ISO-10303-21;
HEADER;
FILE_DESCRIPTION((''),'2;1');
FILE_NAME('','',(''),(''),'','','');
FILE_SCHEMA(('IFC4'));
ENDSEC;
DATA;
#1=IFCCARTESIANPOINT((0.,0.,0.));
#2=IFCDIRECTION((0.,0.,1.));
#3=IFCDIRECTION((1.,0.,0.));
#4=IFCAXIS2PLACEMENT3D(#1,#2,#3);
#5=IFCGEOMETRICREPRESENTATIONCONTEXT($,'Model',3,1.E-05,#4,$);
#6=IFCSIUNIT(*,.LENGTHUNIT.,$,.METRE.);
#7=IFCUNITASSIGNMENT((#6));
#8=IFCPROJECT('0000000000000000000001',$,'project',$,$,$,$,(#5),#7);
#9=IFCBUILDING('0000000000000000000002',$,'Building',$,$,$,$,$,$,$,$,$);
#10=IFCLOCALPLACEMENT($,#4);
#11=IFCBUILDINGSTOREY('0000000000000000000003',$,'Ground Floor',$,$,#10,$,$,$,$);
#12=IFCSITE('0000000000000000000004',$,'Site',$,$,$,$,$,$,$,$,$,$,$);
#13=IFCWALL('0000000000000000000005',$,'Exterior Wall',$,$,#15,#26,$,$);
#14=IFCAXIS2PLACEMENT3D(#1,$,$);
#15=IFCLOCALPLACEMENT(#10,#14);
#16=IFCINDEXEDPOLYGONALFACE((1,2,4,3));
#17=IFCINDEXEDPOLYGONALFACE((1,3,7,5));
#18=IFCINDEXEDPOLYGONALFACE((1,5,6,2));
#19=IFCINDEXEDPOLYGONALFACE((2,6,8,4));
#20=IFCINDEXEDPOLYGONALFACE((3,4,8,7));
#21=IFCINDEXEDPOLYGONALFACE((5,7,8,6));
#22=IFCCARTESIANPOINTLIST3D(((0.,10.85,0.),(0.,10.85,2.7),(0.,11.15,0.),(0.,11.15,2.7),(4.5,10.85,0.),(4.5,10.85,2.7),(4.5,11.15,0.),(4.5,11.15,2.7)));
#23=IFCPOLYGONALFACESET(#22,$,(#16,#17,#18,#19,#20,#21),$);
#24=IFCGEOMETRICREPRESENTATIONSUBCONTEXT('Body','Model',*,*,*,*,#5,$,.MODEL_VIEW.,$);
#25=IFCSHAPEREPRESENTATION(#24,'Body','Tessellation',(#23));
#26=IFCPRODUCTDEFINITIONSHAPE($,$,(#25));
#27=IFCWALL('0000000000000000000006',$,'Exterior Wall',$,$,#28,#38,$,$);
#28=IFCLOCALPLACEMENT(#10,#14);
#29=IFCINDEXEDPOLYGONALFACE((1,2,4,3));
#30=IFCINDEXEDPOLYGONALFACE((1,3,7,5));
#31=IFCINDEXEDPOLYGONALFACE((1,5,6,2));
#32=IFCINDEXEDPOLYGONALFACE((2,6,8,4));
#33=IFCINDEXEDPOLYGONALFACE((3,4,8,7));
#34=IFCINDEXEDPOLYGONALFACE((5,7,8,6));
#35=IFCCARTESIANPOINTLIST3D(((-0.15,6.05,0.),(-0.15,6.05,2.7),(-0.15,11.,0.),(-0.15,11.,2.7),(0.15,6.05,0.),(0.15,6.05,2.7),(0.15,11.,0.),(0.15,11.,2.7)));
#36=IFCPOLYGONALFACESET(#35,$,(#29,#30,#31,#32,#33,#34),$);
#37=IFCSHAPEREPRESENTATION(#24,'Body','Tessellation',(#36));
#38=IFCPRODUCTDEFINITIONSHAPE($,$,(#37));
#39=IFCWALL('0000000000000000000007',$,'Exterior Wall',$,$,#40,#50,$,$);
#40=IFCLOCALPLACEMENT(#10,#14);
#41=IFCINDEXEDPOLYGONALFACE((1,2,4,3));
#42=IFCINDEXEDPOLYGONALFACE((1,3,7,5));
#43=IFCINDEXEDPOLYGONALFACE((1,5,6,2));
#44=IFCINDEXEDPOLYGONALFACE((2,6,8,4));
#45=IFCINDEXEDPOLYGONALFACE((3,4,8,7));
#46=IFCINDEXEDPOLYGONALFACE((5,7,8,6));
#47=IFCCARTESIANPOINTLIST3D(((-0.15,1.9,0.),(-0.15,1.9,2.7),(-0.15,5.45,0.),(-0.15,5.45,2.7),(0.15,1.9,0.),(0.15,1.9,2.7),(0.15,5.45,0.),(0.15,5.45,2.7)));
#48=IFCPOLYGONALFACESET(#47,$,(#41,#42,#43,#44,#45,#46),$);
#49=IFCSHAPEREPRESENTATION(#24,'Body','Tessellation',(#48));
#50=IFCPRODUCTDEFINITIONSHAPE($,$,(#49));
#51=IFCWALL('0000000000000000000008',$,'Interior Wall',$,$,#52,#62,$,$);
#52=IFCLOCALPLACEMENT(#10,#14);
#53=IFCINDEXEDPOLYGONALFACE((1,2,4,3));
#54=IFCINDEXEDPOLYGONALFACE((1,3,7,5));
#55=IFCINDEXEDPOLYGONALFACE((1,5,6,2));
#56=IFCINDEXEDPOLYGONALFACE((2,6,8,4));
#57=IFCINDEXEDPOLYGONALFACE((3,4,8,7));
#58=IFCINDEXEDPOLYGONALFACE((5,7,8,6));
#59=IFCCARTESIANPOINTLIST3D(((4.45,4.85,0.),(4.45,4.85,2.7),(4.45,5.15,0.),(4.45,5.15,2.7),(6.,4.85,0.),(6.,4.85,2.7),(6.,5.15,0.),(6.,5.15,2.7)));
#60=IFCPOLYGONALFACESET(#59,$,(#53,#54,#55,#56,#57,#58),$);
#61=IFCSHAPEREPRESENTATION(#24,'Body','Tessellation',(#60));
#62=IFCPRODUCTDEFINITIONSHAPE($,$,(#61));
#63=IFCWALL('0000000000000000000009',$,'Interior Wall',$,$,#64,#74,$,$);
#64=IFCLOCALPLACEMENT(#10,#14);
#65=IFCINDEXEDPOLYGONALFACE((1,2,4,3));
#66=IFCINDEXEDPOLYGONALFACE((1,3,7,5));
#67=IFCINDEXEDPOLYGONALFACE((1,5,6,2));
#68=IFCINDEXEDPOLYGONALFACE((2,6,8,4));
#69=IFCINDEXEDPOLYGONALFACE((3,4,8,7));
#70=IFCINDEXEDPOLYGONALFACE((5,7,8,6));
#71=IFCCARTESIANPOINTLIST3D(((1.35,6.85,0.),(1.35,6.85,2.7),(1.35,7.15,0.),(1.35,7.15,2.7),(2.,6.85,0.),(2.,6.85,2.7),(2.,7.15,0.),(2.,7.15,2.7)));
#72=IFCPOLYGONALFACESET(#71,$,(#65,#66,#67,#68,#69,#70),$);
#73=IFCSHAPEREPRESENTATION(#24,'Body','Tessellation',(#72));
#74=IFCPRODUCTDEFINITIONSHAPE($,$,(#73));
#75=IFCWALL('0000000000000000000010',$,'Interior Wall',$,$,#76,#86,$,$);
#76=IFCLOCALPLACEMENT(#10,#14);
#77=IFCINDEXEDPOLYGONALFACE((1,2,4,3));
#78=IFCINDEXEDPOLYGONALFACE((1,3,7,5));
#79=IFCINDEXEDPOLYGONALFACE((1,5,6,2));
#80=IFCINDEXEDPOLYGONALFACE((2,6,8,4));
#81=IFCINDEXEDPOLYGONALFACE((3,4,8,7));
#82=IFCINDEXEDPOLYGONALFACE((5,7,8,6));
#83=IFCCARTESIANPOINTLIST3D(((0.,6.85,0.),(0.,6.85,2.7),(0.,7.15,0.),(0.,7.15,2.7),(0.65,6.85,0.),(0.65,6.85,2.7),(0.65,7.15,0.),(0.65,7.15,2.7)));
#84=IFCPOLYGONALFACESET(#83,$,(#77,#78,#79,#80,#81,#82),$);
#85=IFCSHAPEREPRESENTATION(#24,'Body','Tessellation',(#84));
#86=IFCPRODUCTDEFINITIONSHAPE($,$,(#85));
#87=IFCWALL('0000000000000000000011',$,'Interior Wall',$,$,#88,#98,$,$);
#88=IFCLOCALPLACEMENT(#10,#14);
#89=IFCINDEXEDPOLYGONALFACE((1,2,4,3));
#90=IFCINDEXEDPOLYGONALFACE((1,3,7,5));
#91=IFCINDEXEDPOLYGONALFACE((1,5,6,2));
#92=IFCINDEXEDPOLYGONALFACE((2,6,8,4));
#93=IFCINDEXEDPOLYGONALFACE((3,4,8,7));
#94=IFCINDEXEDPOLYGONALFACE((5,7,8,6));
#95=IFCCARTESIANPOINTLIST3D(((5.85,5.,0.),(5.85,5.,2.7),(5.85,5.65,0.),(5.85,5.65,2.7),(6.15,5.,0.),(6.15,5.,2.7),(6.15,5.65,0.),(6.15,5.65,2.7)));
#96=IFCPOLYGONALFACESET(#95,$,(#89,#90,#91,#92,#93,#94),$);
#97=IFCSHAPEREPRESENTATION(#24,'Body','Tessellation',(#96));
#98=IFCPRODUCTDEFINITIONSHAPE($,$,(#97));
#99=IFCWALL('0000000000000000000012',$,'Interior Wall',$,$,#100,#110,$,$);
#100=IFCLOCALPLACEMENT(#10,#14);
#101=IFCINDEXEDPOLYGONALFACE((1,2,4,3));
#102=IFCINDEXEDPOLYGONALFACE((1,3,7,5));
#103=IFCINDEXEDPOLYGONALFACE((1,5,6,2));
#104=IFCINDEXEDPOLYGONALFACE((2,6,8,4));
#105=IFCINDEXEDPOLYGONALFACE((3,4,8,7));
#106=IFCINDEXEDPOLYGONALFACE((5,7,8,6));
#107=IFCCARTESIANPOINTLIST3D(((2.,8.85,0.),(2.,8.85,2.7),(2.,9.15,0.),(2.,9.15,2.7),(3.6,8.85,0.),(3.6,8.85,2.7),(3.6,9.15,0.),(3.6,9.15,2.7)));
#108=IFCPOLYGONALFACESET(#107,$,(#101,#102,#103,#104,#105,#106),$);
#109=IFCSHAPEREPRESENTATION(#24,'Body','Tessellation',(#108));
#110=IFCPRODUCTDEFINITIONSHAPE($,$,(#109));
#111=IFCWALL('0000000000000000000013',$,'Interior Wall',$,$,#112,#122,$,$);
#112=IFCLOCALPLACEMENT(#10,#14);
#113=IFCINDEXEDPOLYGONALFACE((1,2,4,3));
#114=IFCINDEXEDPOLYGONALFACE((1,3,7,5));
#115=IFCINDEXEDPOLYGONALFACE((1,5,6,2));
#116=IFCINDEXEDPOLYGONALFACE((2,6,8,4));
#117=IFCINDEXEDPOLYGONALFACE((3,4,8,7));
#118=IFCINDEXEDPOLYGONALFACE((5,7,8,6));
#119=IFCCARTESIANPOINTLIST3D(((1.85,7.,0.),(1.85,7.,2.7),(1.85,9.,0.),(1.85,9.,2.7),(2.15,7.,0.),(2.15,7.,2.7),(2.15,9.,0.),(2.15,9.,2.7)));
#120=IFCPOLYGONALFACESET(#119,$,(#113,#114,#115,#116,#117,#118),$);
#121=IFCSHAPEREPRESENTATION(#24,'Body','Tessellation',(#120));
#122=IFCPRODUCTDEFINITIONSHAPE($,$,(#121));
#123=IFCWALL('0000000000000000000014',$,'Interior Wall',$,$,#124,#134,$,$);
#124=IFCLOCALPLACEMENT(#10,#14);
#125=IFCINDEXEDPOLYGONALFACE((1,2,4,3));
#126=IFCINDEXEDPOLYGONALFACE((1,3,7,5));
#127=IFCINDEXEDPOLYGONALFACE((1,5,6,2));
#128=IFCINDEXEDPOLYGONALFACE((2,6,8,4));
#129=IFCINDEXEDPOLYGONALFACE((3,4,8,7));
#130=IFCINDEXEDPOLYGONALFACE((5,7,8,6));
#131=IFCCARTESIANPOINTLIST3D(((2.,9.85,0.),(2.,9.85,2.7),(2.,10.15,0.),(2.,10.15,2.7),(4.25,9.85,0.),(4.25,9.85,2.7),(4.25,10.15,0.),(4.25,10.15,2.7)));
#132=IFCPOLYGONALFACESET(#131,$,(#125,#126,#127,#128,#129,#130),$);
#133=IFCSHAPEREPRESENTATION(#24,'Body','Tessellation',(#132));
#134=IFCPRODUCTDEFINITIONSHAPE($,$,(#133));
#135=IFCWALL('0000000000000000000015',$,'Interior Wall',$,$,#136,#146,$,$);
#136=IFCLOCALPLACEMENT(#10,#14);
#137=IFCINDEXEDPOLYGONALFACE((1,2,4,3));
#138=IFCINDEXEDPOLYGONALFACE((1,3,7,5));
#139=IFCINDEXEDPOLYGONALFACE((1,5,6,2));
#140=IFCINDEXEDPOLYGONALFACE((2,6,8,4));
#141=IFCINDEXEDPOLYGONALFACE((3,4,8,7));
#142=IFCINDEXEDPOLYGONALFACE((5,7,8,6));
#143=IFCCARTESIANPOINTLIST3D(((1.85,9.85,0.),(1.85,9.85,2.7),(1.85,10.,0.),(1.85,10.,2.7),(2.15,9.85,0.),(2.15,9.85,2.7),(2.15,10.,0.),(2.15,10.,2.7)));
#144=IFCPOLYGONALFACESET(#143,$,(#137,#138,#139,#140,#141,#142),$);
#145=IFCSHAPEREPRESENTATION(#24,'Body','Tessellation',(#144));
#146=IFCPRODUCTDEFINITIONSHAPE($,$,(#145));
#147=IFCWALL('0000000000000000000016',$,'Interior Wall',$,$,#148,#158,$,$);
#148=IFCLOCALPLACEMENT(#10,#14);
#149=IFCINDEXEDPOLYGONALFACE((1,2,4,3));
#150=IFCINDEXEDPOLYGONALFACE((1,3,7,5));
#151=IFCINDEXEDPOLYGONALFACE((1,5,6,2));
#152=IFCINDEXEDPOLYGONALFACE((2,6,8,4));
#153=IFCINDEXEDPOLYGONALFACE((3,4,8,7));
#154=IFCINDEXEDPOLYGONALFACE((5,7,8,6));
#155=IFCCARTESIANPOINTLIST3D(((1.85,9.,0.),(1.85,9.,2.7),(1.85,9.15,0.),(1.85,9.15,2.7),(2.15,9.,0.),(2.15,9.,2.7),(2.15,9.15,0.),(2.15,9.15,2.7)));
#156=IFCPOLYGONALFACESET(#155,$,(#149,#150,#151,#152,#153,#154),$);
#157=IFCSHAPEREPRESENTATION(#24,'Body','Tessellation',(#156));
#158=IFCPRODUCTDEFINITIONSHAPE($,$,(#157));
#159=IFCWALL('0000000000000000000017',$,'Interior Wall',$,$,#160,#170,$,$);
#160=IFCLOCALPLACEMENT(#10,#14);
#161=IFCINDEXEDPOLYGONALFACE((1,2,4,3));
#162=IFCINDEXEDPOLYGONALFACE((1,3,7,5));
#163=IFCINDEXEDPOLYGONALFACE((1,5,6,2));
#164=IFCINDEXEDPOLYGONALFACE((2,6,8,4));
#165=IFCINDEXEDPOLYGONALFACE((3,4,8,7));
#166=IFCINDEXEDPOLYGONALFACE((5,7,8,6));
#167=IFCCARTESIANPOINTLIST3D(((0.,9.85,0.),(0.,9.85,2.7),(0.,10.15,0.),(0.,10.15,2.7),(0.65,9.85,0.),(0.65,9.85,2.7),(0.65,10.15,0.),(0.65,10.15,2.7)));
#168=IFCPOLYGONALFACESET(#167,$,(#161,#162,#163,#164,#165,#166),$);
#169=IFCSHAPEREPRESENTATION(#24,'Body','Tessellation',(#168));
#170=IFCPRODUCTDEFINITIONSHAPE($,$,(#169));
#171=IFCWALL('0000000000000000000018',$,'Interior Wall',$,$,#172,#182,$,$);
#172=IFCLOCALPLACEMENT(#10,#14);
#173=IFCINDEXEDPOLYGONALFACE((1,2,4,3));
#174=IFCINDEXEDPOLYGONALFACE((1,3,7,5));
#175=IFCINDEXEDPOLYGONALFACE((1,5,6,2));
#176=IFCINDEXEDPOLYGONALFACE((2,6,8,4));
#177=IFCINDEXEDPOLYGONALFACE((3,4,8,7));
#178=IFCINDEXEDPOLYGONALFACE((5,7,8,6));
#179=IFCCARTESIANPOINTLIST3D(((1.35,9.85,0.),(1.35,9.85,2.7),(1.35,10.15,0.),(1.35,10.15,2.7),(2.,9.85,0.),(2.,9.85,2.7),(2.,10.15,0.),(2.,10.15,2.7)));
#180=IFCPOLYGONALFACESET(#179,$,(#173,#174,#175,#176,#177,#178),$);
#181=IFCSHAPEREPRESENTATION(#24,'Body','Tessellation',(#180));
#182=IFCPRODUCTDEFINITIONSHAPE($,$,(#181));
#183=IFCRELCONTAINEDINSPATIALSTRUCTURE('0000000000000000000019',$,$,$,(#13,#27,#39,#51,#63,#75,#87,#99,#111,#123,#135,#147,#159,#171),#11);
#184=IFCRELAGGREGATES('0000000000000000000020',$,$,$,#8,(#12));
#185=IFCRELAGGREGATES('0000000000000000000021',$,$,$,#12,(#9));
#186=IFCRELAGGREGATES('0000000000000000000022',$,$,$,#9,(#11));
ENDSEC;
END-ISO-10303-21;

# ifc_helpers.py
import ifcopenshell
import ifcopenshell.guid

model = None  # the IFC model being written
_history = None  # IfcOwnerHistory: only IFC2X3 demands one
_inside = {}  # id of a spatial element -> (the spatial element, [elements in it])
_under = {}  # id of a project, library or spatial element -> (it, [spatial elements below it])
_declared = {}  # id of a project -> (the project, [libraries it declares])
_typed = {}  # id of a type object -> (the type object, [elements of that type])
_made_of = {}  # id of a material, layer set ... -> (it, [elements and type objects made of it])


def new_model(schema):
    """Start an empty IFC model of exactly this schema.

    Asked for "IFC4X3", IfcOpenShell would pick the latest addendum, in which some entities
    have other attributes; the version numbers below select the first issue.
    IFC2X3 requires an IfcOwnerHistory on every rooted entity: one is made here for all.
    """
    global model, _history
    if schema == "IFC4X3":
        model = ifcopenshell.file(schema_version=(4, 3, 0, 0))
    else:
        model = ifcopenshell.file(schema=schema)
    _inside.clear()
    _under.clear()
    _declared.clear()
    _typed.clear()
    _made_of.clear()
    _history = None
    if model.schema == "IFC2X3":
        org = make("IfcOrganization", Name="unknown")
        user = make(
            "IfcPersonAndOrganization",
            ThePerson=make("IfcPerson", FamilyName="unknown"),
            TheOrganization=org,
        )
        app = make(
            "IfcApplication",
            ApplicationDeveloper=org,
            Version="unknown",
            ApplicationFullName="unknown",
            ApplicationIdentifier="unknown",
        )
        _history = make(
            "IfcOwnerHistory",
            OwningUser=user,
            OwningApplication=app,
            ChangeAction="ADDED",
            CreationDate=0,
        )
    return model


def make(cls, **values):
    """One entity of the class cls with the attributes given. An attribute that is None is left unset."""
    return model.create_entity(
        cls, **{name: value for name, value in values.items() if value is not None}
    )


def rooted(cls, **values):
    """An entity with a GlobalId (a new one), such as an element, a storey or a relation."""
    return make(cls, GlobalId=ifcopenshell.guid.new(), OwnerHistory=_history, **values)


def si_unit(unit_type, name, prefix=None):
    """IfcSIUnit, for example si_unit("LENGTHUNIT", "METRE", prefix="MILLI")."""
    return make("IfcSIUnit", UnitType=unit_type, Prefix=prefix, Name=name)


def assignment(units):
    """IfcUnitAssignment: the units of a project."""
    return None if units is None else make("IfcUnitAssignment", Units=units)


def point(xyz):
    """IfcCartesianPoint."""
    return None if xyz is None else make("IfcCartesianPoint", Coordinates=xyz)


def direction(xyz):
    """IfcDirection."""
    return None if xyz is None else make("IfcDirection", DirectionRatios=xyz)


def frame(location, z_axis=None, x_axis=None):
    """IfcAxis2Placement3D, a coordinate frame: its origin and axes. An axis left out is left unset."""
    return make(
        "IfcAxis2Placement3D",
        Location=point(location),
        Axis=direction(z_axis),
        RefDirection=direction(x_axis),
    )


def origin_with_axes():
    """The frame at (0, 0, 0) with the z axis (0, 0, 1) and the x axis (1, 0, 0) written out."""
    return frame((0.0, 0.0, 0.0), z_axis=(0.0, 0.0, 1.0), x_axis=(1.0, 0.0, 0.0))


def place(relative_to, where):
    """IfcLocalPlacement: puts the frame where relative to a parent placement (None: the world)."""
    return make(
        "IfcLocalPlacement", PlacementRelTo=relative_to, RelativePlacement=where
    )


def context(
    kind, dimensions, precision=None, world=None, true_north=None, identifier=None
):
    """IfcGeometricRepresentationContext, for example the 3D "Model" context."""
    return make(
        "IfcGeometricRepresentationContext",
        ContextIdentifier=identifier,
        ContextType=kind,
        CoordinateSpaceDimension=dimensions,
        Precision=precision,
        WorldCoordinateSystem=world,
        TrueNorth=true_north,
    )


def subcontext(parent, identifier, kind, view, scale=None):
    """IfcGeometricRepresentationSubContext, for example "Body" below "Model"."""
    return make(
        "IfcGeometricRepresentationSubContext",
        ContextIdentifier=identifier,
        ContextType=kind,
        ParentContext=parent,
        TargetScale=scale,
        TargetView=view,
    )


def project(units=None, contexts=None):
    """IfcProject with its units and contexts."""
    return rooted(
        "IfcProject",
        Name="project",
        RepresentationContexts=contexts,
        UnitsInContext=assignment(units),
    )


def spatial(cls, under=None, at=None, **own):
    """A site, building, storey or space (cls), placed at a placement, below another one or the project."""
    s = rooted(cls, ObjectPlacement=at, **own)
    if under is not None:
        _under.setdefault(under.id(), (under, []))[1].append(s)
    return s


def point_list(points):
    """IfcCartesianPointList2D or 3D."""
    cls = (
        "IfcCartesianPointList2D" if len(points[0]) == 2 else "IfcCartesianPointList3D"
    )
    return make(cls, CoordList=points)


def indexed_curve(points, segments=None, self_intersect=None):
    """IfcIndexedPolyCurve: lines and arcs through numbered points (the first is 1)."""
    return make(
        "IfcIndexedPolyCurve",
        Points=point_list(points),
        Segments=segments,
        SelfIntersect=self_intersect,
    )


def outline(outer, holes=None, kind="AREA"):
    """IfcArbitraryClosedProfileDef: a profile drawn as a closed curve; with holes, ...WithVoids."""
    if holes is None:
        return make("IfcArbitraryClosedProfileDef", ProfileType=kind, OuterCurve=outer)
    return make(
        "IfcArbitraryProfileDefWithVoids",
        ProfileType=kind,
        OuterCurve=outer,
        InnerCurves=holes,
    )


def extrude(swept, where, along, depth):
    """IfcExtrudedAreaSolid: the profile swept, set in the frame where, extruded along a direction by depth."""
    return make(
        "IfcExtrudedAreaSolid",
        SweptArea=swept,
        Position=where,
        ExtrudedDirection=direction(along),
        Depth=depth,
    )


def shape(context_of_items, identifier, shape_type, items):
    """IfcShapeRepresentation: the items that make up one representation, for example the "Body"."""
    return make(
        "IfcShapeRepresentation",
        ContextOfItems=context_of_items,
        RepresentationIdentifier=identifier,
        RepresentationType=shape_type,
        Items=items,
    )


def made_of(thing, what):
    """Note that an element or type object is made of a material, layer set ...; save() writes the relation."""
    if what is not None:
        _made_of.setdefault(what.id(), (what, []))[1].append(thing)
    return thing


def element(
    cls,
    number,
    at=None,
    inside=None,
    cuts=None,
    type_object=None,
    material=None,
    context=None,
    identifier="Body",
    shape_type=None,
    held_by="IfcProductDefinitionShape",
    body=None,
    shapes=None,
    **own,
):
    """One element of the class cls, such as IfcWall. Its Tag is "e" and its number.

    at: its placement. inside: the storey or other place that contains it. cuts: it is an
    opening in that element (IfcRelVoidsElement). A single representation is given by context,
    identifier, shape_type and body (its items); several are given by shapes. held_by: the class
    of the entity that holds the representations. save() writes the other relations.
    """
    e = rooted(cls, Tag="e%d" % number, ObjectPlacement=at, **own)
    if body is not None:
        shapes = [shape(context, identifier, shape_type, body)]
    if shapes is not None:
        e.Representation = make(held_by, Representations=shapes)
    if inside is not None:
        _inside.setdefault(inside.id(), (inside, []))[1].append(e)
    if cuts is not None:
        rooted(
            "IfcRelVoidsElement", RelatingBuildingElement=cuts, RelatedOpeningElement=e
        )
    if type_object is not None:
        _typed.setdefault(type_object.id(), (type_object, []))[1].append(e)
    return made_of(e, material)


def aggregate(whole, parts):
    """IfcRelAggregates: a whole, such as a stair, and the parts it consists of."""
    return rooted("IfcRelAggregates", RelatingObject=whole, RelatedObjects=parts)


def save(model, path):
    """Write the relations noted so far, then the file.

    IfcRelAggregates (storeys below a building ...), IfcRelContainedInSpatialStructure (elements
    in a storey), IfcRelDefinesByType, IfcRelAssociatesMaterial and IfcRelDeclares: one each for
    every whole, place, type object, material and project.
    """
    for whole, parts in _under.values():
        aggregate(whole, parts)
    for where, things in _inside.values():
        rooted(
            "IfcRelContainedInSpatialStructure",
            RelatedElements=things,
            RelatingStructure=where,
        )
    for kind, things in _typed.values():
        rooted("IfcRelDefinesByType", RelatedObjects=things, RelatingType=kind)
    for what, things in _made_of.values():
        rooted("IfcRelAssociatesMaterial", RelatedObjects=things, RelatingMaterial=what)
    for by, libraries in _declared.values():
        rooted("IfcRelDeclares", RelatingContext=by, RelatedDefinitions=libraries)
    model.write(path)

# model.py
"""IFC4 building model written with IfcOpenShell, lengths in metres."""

from ifc_helpers import new_model, si_unit, frame, origin_with_axes, place, context, subcontext, project, spatial, indexed_curve, outline, extrude, element, save


model = new_model("IFC4")

# Units and contexts
model_context = context("Model", 3, precision=1e-05, world=origin_with_axes())
body_context = subcontext(model_context, "Body", "Model", "MODEL_VIEW")
ifc_project = project(units=[si_unit("LENGTHUNIT", "METRE")], contexts=[model_context])

# Site, building, storey
site = spatial("IfcSite", under=ifc_project, Name="Site")
building = spatial("IfcBuilding", under=site, Name="Building")
storey_placement = place(None, origin_with_axes())
storey = spatial("IfcBuildingStorey", under=building, at=storey_placement, Name="Ground Floor")

# Walls
wall_1_placement = place(storey_placement, frame((4.5, 11.0, 0.0), z_axis=(0.0, 0.0, 1.0), x_axis=(-1.0, 0.0, 0.0)))
element("IfcWall", 1, at=wall_1_placement, inside=storey, Name="Exterior Wall", context=body_context, shape_type="SweptSolid", body=[
    extrude(outline(indexed_curve([(0.0, 0.0), (0.0, 0.3), (4.5, 0.3), (4.5, 0.0), (0.0, 0.0)], self_intersect=False)), frame((0.0, -0.15, 0.0), z_axis=(0.0, 0.0, 1.0), x_axis=(1.0, 0.0, 0.0)), (0.0, 0.0, 1.0), 2.7),
])
wall_2_placement = place(storey_placement, frame((0.0, 11.0, 0.0), z_axis=(0.0, 0.0, 1.0), x_axis=(0.0, -1.0, 0.0)))
element("IfcWall", 2, at=wall_2_placement, inside=storey, Name="Exterior Wall", context=body_context, shape_type="SweptSolid", body=[
    extrude(outline(indexed_curve([(0.0, 0.0), (0.0, 0.3), (4.95, 0.3), (4.95, 0.0), (0.0, 0.0)], self_intersect=False)), frame((0.0, -0.15, 0.0), z_axis=(0.0, 0.0, 1.0), x_axis=(1.0, 0.0, 0.0)), (0.0, 0.0, 1.0), 2.7),
])
wall_3_placement = place(storey_placement, frame((0.0, 5.45, 0.0), z_axis=(0.0, 0.0, 1.0), x_axis=(0.0, -1.0, 0.0)))
element("IfcWall", 3, at=wall_3_placement, inside=storey, Name="Exterior Wall", context=body_context, shape_type="SweptSolid", body=[
    extrude(outline(indexed_curve([(0.0, 0.0), (0.0, 0.3), (3.55, 0.3), (3.55, 0.0), (0.0, 0.0)], self_intersect=False)), frame((0.0, -0.15, 0.0), z_axis=(0.0, 0.0, 1.0), x_axis=(1.0, 0.0, 0.0)), (0.0, 0.0, 1.0), 2.7),
])
wall_4_placement = place(storey_placement, frame((6.0, 5.0, 0.0), z_axis=(0.0, 0.0, 1.0), x_axis=(-1.0, 0.0, 0.0)))
element("IfcWall", 4, at=wall_4_placement, inside=storey, Name="Interior Wall", context=body_context, shape_type="SweptSolid", body=[
    extrude(outline(indexed_curve([(0.0, 0.0), (0.0, 0.3), (1.55, 0.3), (1.55, 0.0), (0.0, 0.0)], self_intersect=False)), frame((0.0, -0.15, 0.0), z_axis=(0.0, 0.0, 1.0), x_axis=(1.0, 0.0, 0.0)), (0.0, 0.0, 1.0), 2.7),
])
for number, where, z_axis, x_axis, name in (
    (5, (2.0, 7.0, 0.0), (0.0, 0.0, 1.0), (-1.0, 0.0, 0.0), "Interior Wall"),
    (6, (0.65, 7.0, 0.0), (0.0, 0.0, 1.0), (-1.0, 0.0, 0.0), "Interior Wall"),
):
    element("IfcWall", number, at=place(storey_placement, frame(where, z_axis=z_axis, x_axis=x_axis)), inside=storey, Name=name, context=body_context, shape_type="SweptSolid", body=[
        extrude(outline(indexed_curve([(0.0, 0.0), (0.0, 0.3), (0.65, 0.3), (0.65, 0.0), (0.0, 0.0)], self_intersect=False)), frame((0.0, -0.15, 0.0), z_axis=(0.0, 0.0, 1.0), x_axis=(1.0, 0.0, 0.0)), (0.0, 0.0, 1.0), 2.7),
    ])
wall_5_placement = place(storey_placement, frame((6.0, 5.0, 0.0), z_axis=(0.0, 0.0, 1.0), x_axis=(0.0, 1.0, 0.0)))
element("IfcWall", 7, at=wall_5_placement, inside=storey, Name="Interior Wall", context=body_context, shape_type="SweptSolid", body=[
    extrude(outline(indexed_curve([(0.0, 0.0), (0.0, 0.3), (0.65, 0.3), (0.65, 0.0), (0.0, 0.0)], self_intersect=False)), frame((0.0, -0.15, 0.0), z_axis=(0.0, 0.0, 1.0), x_axis=(1.0, 0.0, 0.0)), (0.0, 0.0, 1.0), 2.7),
])
wall_6_placement = place(storey_placement, frame((3.6, 9.0, 0.0), z_axis=(0.0, 0.0, 1.0), x_axis=(-1.0, 0.0, 0.0)))
element("IfcWall", 8, at=wall_6_placement, inside=storey, Name="Interior Wall", context=body_context, shape_type="SweptSolid", body=[
    extrude(outline(indexed_curve([(0.0, 0.0), (0.0, 0.3), (1.6, 0.3), (1.6, 0.0), (0.0, 0.0)], self_intersect=False)), frame((0.0, -0.15, 0.0), z_axis=(0.0, 0.0, 1.0), x_axis=(1.0, 0.0, 0.0)), (0.0, 0.0, 1.0), 2.7),
])
wall_7_placement = place(storey_placement, frame((2.0, 9.0, 0.0), z_axis=(0.0, 0.0, 1.0), x_axis=(0.0, -1.0, 0.0)))
element("IfcWall", 9, at=wall_7_placement, inside=storey, Name="Interior Wall", context=body_context, shape_type="SweptSolid", body=[
    extrude(outline(indexed_curve([(0.0, 0.0), (0.0, 0.3), (2.0, 0.3), (2.0, 0.0), (0.0, 0.0)], self_intersect=False)), frame((0.0, -0.15, 0.0), z_axis=(0.0, 0.0, 1.0), x_axis=(1.0, 0.0, 0.0)), (0.0, 0.0, 1.0), 2.7),
])
wall_8_placement = place(storey_placement, frame((4.25, 10.0, 0.0), z_axis=(0.0, 0.0, 1.0), x_axis=(-1.0, 0.0, 0.0)))
element("IfcWall", 10, at=wall_8_placement, inside=storey, Name="Interior Wall", context=body_context, shape_type="SweptSolid", body=[
    extrude(outline(indexed_curve([(0.0, 0.0), (0.0, 0.3), (2.25, 0.3), (2.25, 0.0), (0.0, 0.0)], self_intersect=False)), frame((0.0, -0.15, 0.0), z_axis=(0.0, 0.0, 1.0), x_axis=(1.0, 0.0, 0.0)), (0.0, 0.0, 1.0), 2.7),
])
for number, where, z_axis, x_axis, name in (
    (11, (2.0, 10.0, 0.0), (0.0, 0.0, 1.0), (0.0, -1.0, 0.0), "Interior Wall"),
    (12, (2.0, 9.15, 0.0), (0.0, 0.0, 1.0), (0.0, -1.0, 0.0), "Interior Wall"),
):
    element("IfcWall", number, at=place(storey_placement, frame(where, z_axis=z_axis, x_axis=x_axis)), inside=storey, Name=name, context=body_context, shape_type="SweptSolid", body=[
        extrude(outline(indexed_curve([(0.0, 0.0), (0.0, 0.3), (0.15, 0.3), (0.15, 0.0), (0.0, 0.0)], self_intersect=False)), frame((0.0, -0.15, 0.0), z_axis=(0.0, 0.0, 1.0), x_axis=(1.0, 0.0, 0.0)), (0.0, 0.0, 1.0), 2.7),
    ])
wall_9_placement = place(storey_placement, frame((0.0, 10.0, 0.0), z_axis=(0.0, 0.0, 1.0), x_axis=(1.0, 0.0, 0.0)))
element("IfcWall", 13, at=wall_9_placement, inside=storey, Name="Interior Wall", context=body_context, shape_type="SweptSolid", body=[
    extrude(outline(indexed_curve([(0.0, 0.0), (0.0, 0.3), (0.65, 0.3), (0.65, 0.0), (0.0, 0.0)], self_intersect=False)), frame((0.0, -0.15, 0.0), z_axis=(0.0, 0.0, 1.0), x_axis=(1.0, 0.0, 0.0)), (0.0, 0.0, 1.0), 2.7),
])
wall_10_placement = place(storey_placement, frame((1.35, 10.0, 0.0), z_axis=(0.0, 0.0, 1.0), x_axis=(1.0, 0.0, 0.0)))
element("IfcWall", 14, at=wall_10_placement, inside=storey, Name="Interior Wall", context=body_context, shape_type="SweptSolid", body=[
    extrude(outline(indexed_curve([(0.0, 0.0), (0.0, 0.3), (0.65, 0.3), (0.65, 0.0), (0.0, 0.0)], self_intersect=False)), frame((0.0, -0.15, 0.0), z_axis=(0.0, 0.0, 1.0), x_axis=(1.0, 0.0, 0.0)), (0.0, 0.0, 1.0), 2.7),
])

save(model, "model.ifc")
